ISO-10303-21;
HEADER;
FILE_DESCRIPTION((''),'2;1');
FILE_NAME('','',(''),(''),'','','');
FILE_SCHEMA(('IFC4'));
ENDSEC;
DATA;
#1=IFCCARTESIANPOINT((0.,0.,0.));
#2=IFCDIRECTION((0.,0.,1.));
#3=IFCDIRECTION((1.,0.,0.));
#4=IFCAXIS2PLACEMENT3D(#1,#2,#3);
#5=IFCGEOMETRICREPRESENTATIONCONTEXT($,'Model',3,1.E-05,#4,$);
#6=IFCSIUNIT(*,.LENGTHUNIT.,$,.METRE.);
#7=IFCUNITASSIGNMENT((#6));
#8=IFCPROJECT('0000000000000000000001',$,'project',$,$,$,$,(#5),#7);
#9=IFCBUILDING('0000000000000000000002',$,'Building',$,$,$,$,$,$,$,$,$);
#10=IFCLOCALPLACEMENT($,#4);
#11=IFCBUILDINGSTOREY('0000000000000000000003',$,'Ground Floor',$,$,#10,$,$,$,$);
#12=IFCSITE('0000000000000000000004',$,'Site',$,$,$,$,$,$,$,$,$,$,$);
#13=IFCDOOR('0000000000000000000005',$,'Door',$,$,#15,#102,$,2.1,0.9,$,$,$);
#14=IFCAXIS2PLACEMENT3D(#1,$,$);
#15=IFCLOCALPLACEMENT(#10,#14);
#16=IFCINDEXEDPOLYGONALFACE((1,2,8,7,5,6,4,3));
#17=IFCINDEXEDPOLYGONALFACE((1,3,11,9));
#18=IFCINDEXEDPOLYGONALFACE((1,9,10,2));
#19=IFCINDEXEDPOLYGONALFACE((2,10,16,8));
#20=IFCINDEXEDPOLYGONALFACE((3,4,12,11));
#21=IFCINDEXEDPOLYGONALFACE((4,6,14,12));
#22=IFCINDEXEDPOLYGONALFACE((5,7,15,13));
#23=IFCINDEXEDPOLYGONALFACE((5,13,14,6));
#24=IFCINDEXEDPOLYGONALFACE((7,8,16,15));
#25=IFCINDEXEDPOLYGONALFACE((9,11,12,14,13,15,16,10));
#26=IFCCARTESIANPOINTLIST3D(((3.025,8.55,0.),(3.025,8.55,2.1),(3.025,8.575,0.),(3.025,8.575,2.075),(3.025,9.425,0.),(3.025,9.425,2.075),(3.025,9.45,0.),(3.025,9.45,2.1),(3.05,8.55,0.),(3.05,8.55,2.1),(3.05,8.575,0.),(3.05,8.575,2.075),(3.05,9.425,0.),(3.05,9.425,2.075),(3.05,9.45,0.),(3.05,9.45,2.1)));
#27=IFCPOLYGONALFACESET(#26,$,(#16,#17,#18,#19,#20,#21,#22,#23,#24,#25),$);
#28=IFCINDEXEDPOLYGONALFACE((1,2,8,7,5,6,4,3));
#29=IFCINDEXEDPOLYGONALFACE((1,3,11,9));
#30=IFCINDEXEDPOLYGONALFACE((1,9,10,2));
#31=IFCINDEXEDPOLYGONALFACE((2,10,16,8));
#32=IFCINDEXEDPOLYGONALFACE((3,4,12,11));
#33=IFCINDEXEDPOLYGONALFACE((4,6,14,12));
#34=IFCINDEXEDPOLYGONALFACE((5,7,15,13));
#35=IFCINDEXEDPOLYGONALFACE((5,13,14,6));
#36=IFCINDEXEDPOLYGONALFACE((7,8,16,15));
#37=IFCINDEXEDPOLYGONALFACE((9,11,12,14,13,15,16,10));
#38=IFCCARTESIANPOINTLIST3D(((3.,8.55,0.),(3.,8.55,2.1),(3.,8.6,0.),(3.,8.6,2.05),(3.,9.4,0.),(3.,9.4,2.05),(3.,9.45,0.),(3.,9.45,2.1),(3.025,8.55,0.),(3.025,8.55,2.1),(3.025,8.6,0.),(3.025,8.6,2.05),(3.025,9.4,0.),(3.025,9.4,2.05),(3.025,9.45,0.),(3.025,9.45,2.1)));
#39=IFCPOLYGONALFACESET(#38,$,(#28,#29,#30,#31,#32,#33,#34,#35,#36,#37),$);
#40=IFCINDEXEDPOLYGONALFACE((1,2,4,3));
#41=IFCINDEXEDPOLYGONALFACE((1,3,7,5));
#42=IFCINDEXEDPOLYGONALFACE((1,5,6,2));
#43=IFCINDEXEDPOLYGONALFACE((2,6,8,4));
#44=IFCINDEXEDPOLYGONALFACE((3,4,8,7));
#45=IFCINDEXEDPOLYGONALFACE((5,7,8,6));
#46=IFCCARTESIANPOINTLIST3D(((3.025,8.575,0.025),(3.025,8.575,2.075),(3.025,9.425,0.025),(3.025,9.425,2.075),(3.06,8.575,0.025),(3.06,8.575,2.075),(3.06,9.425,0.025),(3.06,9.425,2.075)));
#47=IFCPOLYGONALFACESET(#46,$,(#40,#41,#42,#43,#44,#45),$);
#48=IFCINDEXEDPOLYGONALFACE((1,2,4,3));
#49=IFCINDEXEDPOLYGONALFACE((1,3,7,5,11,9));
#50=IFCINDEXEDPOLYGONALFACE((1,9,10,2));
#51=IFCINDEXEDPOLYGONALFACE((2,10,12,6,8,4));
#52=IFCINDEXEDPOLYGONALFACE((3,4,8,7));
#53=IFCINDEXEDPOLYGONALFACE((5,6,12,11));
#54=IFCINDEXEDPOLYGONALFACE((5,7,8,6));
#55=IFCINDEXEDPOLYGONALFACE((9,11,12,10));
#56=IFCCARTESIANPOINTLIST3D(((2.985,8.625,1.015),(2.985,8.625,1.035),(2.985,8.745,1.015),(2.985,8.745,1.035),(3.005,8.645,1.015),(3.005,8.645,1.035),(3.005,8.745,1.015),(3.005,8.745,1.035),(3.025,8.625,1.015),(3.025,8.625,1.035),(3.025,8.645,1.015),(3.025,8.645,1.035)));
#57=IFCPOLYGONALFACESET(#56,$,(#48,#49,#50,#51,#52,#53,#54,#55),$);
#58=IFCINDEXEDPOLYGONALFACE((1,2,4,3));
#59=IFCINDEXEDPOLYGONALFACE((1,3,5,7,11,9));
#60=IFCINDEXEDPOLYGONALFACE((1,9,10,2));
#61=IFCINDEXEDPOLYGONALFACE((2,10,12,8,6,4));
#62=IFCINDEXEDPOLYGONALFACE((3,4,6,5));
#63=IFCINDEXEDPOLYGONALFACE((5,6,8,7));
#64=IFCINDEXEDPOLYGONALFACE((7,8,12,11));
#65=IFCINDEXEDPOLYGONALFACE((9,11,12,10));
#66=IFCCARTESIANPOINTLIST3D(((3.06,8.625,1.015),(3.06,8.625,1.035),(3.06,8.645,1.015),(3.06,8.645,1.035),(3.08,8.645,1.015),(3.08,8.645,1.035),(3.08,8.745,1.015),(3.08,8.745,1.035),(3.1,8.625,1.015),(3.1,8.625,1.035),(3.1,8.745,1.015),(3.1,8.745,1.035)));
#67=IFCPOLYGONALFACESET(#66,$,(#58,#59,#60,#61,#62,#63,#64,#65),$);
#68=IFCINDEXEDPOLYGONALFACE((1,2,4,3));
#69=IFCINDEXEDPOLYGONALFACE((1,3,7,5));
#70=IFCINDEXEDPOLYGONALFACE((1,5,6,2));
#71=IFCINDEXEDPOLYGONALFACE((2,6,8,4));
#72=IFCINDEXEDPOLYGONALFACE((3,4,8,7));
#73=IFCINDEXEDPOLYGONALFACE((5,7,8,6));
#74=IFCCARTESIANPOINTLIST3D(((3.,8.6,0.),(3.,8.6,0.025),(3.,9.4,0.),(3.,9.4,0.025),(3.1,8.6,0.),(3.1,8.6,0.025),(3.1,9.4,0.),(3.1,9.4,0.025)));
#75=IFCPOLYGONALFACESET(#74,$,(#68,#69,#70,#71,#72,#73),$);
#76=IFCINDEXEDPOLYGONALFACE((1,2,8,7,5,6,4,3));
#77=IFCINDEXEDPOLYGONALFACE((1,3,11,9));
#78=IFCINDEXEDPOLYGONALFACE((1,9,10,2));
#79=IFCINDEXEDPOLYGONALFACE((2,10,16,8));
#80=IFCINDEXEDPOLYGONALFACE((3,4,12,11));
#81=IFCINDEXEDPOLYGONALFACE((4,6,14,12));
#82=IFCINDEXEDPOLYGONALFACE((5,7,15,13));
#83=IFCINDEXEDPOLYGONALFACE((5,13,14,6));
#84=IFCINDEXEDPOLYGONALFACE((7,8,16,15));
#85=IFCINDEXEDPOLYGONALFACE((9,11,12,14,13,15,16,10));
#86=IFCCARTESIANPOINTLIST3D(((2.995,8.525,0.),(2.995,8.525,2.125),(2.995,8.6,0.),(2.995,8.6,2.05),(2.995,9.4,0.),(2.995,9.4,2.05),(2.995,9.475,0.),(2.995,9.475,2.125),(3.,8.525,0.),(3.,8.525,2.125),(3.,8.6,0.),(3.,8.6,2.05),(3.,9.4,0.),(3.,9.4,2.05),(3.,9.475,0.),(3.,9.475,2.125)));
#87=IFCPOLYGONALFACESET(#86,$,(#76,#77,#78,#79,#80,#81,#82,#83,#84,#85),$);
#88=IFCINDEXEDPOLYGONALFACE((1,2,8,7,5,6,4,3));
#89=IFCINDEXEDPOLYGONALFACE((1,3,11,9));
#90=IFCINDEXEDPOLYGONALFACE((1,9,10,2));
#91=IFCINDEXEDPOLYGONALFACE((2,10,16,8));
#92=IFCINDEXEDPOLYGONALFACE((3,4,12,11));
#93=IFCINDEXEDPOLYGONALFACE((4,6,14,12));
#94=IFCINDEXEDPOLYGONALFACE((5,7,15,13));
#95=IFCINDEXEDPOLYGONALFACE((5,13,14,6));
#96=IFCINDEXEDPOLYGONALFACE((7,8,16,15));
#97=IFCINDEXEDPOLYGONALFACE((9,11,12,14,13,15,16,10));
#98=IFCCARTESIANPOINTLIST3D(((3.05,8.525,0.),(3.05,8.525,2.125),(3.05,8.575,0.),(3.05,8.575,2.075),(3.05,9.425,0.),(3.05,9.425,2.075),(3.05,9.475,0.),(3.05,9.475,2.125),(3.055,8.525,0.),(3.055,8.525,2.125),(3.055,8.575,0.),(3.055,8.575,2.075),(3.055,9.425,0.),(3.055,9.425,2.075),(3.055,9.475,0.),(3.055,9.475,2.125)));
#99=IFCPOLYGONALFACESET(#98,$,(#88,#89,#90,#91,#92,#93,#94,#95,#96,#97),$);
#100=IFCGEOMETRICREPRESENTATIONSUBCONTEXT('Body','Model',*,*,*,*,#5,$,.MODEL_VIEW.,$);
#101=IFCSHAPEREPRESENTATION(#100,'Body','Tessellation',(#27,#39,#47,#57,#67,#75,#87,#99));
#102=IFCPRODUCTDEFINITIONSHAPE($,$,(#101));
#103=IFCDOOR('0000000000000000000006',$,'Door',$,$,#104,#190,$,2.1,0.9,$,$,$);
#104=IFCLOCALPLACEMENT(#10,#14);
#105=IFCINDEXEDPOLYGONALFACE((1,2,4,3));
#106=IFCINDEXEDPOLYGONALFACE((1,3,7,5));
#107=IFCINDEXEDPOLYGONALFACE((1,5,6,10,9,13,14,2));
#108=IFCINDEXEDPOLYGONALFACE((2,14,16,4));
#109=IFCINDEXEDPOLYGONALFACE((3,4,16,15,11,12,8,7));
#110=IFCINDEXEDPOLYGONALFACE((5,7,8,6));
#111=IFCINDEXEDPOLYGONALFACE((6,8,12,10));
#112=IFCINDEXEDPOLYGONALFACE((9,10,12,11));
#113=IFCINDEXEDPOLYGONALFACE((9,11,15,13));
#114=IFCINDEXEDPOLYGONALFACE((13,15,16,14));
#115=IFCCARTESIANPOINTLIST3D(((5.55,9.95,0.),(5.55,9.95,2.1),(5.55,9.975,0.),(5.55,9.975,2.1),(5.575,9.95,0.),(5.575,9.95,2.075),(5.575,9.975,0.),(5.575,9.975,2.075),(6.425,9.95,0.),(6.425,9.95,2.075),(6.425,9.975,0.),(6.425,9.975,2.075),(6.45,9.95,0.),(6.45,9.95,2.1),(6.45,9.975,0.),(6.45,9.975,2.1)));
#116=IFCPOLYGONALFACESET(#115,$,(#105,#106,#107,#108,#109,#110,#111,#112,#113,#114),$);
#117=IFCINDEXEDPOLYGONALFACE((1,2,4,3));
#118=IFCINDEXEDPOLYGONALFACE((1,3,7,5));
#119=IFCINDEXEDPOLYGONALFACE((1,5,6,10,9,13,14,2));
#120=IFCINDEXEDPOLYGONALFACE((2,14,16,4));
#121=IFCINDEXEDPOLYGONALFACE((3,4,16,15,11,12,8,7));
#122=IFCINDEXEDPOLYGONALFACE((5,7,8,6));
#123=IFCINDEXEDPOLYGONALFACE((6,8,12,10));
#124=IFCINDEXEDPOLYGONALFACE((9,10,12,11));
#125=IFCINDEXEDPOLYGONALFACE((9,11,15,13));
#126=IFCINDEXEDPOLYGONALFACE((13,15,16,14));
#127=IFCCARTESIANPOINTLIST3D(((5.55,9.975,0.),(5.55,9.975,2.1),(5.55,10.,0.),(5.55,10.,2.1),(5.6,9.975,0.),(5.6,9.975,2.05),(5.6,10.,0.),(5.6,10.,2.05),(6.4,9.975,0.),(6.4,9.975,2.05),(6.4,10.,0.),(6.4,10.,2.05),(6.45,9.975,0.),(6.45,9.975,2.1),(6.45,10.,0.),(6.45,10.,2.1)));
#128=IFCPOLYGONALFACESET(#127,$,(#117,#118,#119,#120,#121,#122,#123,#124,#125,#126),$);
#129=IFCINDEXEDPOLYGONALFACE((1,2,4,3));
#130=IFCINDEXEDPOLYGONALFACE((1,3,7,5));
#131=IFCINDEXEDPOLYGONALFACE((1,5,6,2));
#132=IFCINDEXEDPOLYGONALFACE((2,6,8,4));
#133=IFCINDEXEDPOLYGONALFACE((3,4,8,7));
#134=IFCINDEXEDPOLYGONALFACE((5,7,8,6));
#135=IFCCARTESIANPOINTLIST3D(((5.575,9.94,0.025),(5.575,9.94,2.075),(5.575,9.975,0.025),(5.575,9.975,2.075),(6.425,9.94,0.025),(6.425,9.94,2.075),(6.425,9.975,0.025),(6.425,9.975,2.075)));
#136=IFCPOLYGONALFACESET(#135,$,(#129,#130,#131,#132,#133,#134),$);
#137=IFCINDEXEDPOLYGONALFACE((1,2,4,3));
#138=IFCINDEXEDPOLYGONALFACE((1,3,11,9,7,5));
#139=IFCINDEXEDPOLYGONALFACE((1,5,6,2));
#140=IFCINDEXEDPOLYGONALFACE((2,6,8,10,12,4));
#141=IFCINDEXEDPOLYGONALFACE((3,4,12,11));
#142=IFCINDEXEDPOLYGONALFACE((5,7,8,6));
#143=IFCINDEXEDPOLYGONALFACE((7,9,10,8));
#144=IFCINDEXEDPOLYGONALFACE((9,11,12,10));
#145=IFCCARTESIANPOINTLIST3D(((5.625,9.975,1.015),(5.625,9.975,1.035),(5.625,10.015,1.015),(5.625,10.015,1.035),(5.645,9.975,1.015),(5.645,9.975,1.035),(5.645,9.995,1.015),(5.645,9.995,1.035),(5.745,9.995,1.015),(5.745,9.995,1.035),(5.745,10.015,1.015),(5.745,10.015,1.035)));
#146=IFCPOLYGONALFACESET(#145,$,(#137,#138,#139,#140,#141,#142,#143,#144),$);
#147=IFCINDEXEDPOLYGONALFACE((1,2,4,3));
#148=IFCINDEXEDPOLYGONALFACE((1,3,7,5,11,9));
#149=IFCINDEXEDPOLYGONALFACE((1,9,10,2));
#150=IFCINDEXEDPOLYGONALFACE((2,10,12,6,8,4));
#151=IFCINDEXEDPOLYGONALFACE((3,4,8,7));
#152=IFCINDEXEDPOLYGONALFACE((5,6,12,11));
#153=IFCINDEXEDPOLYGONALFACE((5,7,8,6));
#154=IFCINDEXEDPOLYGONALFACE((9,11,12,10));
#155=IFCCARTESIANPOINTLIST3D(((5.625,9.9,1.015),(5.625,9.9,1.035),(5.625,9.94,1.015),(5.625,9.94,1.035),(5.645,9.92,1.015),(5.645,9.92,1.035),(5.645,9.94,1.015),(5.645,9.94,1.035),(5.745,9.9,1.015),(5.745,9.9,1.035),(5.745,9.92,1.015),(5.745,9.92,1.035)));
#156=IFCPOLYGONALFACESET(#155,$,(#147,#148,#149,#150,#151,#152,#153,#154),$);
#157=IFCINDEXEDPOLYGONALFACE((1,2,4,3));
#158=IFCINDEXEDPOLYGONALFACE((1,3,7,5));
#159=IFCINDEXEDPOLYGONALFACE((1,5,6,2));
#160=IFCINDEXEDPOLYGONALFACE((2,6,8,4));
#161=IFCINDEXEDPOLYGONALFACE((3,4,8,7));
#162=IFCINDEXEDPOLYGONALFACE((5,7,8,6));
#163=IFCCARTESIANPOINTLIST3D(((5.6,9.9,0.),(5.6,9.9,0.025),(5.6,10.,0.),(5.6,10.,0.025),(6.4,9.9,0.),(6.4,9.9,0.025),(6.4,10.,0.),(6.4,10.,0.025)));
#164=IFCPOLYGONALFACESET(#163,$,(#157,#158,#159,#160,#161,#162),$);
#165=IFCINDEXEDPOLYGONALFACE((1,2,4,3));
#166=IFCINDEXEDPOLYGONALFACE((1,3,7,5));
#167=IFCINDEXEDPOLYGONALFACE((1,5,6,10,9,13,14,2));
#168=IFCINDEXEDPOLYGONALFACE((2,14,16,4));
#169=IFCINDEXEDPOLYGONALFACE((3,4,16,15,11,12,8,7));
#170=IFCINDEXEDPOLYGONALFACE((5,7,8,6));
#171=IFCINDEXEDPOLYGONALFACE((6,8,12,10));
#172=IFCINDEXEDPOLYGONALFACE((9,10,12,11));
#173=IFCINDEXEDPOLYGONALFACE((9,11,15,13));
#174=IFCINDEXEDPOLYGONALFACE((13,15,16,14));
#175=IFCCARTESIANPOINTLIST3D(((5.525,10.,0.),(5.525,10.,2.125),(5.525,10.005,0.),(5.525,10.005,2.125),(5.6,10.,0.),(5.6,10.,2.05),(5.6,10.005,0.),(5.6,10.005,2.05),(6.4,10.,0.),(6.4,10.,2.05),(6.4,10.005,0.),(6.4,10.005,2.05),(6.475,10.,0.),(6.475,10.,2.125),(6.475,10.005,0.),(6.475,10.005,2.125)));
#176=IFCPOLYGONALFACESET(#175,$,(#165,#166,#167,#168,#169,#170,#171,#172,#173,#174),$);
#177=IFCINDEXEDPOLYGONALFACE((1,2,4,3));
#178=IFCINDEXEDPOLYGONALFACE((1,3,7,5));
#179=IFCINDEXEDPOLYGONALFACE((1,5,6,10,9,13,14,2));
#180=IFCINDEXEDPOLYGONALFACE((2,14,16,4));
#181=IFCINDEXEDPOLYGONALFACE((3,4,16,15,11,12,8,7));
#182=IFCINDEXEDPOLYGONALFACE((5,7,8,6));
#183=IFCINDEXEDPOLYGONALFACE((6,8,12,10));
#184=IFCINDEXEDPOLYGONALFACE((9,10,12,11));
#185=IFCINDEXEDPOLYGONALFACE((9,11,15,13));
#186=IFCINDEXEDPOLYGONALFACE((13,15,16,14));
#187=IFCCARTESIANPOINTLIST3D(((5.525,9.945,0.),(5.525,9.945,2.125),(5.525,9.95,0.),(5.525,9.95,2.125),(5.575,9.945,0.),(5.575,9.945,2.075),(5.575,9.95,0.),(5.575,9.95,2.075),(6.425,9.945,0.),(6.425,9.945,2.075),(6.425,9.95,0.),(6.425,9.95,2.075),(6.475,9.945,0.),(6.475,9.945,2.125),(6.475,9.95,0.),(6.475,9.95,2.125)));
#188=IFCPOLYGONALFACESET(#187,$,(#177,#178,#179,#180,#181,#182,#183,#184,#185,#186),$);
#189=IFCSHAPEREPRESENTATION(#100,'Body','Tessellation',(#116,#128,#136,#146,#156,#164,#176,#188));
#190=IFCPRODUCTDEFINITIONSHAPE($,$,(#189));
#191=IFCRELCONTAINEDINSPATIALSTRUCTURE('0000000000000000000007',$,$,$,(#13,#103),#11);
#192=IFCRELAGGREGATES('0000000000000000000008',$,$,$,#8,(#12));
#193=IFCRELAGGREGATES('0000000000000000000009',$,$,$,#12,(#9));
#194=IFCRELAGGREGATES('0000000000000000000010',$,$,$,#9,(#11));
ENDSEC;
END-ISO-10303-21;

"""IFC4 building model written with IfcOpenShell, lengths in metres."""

from ifc_helpers import new_model, si_unit, frame, origin_with_axes, place, context, subcontext, project, spatial, line, indexed_curve, outline, extrude, element, save


model = new_model("IFC4")

# Units and contexts
model_context = context("Model", 3, precision=1e-05, world=origin_with_axes())
body_context = subcontext(model_context, "Body", "Model", "MODEL_VIEW")
ifc_project = project(units=[si_unit("LENGTHUNIT", "METRE")], contexts=[model_context])

# Site, building, storey
site = spatial("IfcSite", under=ifc_project, Name="Site")
building = spatial("IfcBuilding", under=site, Name="Building")
storey_placement = place(None, origin_with_axes())
storey = spatial("IfcBuildingStorey", under=building, at=storey_placement, Name="Ground Floor")

# Doors
door_1_placement = place(storey_placement, frame((3.0, 9.45, 0.0), z_axis=(0.0, 0.0, 1.0), x_axis=(0.0, -1.0, 0.0)))
element("IfcDoor", 1, at=door_1_placement, inside=storey, Name="Door", OverallHeight=2.1, OverallWidth=0.9, context=body_context, shape_type="SweptSolid", body=[
    extrude(outline(indexed_curve([(0.0, 0.0), (0.0, 2.1), (0.9, 2.1), (0.9, 0.0), (0.875, 0.0), (0.875, 2.075), (0.025, 2.075), (0.025, 0.0)], segments=[line(1, 2, 3, 4, 5, 6, 7, 8, 1)])), frame((0.0, 0.025, 0.0), z_axis=(0.0, -1.0, 0.0), x_axis=(1.0, 0.0, 0.0)), (0.0, 0.0, -1.0), 0.025),
    extrude(outline(indexed_curve([(0.0, 0.0), (0.0, 2.1), (0.9, 2.1), (0.9, 0.0), (0.85, 0.0), (0.85, 2.05), (0.05, 2.05), (0.05, 0.0)], segments=[line(1, 2, 3, 4, 5, 6, 7, 8, 1)])), frame((0.0, 0.0, 0.0), z_axis=(0.0, -1.0, 0.0), x_axis=(1.0, 0.0, 0.0)), (0.0, 0.0, -1.0), 0.025),
    extrude(outline(indexed_curve([(0.0, 0.0), (0.85, 0.0), (0.85, 0.035), (0.0, 0.035)], segments=[line(1, 2, 3, 4, 1)])), frame((0.025, 0.025, 0.025), z_axis=(0.0, 0.0, 1.0), x_axis=(1.0, 0.0, 0.0)), (0.0, 0.0, 1.0), 2.05),
    extrude(outline(indexed_curve([(0.0, 0.0), (0.0, -0.04), (-0.12, -0.04), (-0.12, -0.02), (-0.02, -0.02), (-0.02, 0.0)], segments=[line(1, 2, 3, 4, 5, 6, 1)])), frame((0.825, 0.025, 1.015), z_axis=(0.0, 0.0, 1.0), x_axis=(1.0, 0.0, 0.0)), (0.0, 0.0, 1.0), 0.02),
    extrude(outline(indexed_curve([(0.0, 0.0), (0.0, 0.04), (-0.12, 0.04), (-0.12, 0.02), (-0.02, 0.02), (-0.02, 0.0)], segments=[line(1, 2, 3, 4, 5, 6, 1)])), frame((0.825, 0.06, 1.015), z_axis=(0.0, 0.0, 1.0), x_axis=(1.0, 0.0, 0.0)), (0.0, 0.0, 1.0), 0.02),
    extrude(outline(indexed_curve([(0.0, 0.0), (0.8, 0.0), (0.8, 0.1), (0.0, 0.1)], segments=[line(1, 2, 3, 4, 1)])), frame((0.05, 0.0, 0.0), z_axis=(0.0, 0.0, 1.0), x_axis=(1.0, 0.0, 0.0)), (0.0, 0.0, 1.0), 0.025),
    extrude(outline(indexed_curve([(0.0, 0.0), (0.0, 2.125), (0.95, 2.125), (0.95, 0.0), (0.875, 0.0), (0.875, 2.05), (0.075, 2.05), (0.075, 0.0)], segments=[line(1, 2, 3, 4, 5, 6, 7, 8, 1)])), frame((-0.025, -0.005, 0.0), z_axis=(0.0, -1.0, 0.0), x_axis=(1.0, 0.0, 0.0)), (0.0, 0.0, -1.0), 0.005),
    extrude(outline(indexed_curve([(0.0, 0.0), (0.0, 2.125), (0.95, 2.125), (0.95, 0.0), (0.9, 0.0), (0.9, 2.075), (0.05, 2.075), (0.05, 0.0)], segments=[line(1, 2, 3, 4, 5, 6, 7, 8, 1)])), frame((-0.025, 0.05, 0.0), z_axis=(0.0, -1.0, 0.0), x_axis=(1.0, 0.0, 0.0)), (0.0, 0.0, -1.0), 0.005),
])
door_2_placement = place(storey_placement, frame((6.45, 10.0, 0.0), z_axis=(0.0, 0.0, 1.0), x_axis=(-1.0, 0.0, 0.0)))
element("IfcDoor", 2, at=door_2_placement, inside=storey, Name="Door", OverallHeight=2.1, OverallWidth=0.9, context=body_context, shape_type="SweptSolid", body=[
    extrude(outline(indexed_curve([(0.0, 0.0), (0.0, 2.1), (0.9, 2.1), (0.9, 0.0), (0.875, 0.0), (0.875, 2.075), (0.025, 2.075), (0.025, 0.0)], segments=[line(1, 2, 3, 4, 5, 6, 7, 8, 1)])), frame((0.0, 0.025, 0.0), z_axis=(0.0, -1.0, 0.0), x_axis=(1.0, 0.0, 0.0)), (0.0, 0.0, -1.0), 0.025),
    extrude(outline(indexed_curve([(0.0, 0.0), (0.0, 2.1), (0.9, 2.1), (0.9, 0.0), (0.85, 0.0), (0.85, 2.05), (0.05, 2.05), (0.05, 0.0)], segments=[line(1, 2, 3, 4, 5, 6, 7, 8, 1)])), frame((0.0, 0.0, 0.0), z_axis=(0.0, -1.0, 0.0), x_axis=(1.0, 0.0, 0.0)), (0.0, 0.0, -1.0), 0.025),
    extrude(outline(indexed_curve([(0.0, 0.0), (0.85, 0.0), (0.85, 0.035), (0.0, 0.035)], segments=[line(1, 2, 3, 4, 1)])), frame((0.025, 0.025, 0.025), z_axis=(0.0, 0.0, 1.0), x_axis=(1.0, 0.0, 0.0)), (0.0, 0.0, 1.0), 2.05),
    extrude(outline(indexed_curve([(0.0, 0.0), (0.0, -0.04), (-0.12, -0.04), (-0.12, -0.02), (-0.02, -0.02), (-0.02, 0.0)], segments=[line(1, 2, 3, 4, 5, 6, 1)])), frame((0.825, 0.025, 1.015), z_axis=(0.0, 0.0, 1.0), x_axis=(1.0, 0.0, 0.0)), (0.0, 0.0, 1.0), 0.02),
    extrude(outline(indexed_curve([(0.0, 0.0), (0.0, 0.04), (-0.12, 0.04), (-0.12, 0.02), (-0.02, 0.02), (-0.02, 0.0)], segments=[line(1, 2, 3, 4, 5, 6, 1)])), frame((0.825, 0.06, 1.015), z_axis=(0.0, 0.0, 1.0), x_axis=(1.0, 0.0, 0.0)), (0.0, 0.0, 1.0), 0.02),
    extrude(outline(indexed_curve([(0.0, 0.0), (0.8, 0.0), (0.8, 0.1), (0.0, 0.1)], segments=[line(1, 2, 3, 4, 1)])), frame((0.05, 0.0, 0.0), z_axis=(0.0, 0.0, 1.0), x_axis=(1.0, 0.0, 0.0)), (0.0, 0.0, 1.0), 0.025),
    extrude(outline(indexed_curve([(0.0, 0.0), (0.0, 2.125), (0.95, 2.125), (0.95, 0.0), (0.875, 0.0), (0.875, 2.05), (0.075, 2.05), (0.075, 0.0)], segments=[line(1, 2, 3, 4, 5, 6, 7, 8, 1)])), frame((-0.025, -0.005, 0.0), z_axis=(0.0, -1.0, 0.0), x_axis=(1.0, 0.0, 0.0)), (0.0, 0.0, -1.0), 0.005),
    extrude(outline(indexed_curve([(0.0, 0.0), (0.0, 2.125), (0.95, 2.125), (0.95, 0.0), (0.9, 0.0), (0.9, 2.075), (0.05, 2.075), (0.05, 0.0)], segments=[line(1, 2, 3, 4, 5, 6, 7, 8, 1)])), frame((-0.025, 0.05, 0.0), z_axis=(0.0, -1.0, 0.0), x_axis=(1.0, 0.0, 0.0)), (0.0, 0.0, -1.0), 0.005),
])

save(model, "model.ifc")
